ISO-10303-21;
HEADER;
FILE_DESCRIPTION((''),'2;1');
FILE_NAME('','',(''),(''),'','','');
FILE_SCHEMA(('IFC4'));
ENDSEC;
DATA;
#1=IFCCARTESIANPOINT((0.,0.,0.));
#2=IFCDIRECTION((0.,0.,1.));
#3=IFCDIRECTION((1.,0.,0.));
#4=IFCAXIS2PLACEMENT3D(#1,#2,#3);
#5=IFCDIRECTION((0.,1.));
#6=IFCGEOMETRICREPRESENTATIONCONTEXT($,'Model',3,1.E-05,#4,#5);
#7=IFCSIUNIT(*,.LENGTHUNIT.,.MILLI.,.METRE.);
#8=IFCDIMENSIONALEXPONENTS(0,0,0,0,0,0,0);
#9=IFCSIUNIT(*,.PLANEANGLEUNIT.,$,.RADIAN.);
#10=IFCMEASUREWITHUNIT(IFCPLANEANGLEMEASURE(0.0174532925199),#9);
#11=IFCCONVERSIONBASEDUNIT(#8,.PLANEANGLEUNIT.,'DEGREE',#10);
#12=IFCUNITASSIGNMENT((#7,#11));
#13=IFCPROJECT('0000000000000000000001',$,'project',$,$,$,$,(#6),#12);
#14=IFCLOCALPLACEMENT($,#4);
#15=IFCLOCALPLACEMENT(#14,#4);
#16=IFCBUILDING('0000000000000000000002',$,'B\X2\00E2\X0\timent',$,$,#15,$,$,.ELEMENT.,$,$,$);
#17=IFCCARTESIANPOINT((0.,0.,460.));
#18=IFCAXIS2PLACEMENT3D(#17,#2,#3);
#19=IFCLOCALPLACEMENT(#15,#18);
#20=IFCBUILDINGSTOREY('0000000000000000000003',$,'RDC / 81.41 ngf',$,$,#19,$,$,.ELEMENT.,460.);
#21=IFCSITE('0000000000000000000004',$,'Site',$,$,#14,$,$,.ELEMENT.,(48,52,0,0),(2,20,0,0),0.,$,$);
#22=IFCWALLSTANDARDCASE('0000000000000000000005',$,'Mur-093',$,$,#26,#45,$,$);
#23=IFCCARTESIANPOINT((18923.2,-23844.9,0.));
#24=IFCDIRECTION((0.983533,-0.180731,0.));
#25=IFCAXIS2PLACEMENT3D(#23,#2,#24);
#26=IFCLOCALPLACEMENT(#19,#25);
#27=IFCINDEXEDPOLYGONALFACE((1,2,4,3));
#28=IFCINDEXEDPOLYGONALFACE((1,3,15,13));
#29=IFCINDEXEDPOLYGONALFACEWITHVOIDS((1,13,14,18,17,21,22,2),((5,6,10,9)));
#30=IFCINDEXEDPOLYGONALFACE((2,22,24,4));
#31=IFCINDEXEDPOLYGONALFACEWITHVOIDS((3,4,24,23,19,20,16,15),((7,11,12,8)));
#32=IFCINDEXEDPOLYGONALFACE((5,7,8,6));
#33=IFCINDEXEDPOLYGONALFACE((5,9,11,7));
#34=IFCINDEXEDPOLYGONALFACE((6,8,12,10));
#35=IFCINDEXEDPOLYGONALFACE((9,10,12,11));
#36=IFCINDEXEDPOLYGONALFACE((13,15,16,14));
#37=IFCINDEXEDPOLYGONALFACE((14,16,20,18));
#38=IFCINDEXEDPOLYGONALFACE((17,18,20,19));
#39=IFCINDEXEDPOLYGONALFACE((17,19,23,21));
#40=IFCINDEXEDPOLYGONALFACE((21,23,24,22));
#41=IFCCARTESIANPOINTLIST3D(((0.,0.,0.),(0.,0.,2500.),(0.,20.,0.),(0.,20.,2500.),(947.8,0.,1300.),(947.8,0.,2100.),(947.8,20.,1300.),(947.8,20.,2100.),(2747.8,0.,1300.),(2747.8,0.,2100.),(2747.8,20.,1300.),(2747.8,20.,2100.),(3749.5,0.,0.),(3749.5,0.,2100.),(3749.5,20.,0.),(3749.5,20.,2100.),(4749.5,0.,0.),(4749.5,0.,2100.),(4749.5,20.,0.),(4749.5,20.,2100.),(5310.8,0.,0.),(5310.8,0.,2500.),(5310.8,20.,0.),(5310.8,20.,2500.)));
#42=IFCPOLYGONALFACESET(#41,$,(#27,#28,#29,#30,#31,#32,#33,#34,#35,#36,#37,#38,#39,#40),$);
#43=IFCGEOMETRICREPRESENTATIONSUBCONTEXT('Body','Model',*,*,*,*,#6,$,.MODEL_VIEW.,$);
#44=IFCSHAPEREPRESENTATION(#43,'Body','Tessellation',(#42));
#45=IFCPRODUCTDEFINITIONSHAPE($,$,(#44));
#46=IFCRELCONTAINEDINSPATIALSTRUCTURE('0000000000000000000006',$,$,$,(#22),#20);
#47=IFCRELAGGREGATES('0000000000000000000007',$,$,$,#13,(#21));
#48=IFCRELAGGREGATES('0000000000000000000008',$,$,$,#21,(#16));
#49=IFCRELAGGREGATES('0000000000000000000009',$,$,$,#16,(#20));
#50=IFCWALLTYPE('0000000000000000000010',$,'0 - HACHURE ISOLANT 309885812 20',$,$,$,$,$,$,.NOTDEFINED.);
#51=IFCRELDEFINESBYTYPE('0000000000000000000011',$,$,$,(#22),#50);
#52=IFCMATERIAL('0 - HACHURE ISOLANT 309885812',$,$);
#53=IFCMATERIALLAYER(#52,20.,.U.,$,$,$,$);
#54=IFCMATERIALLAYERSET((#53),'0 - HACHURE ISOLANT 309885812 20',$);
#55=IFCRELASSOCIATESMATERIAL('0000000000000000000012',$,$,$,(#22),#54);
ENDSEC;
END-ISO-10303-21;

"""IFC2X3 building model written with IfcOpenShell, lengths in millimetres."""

from ifc_helpers import new_model, entity, si_unit, converted_unit, direction, frame, origin_with_axes, origin_2d_with_axis, place, context, subcontext, project, spatial, polyline, rectangle, outline, extrude, material, layer, layer_set, layer_usage, type_object, element, save


model = new_model("IFC2X3")

# Units and contexts
model_context = context("Model", 3, precision=1e-05, world=origin_with_axes(), true_north=direction((0.0, 1.0)))
body_context = subcontext(model_context, "Body", "Model", "MODEL_VIEW")
ifc_project = project(units=[si_unit("LENGTHUNIT", "METRE", prefix="MILLI"), converted_unit("PLANEANGLEUNIT", "DEGREE", entity("IfcPlaneAngleMeasure", 0.0174532925199), si_unit("PLANEANGLEUNIT", "RADIAN"), dimensions=[0, 0, 0, 0, 0, 0, 0])], contexts=[model_context])

# Site, building, storey
site_placement = place(None, origin_with_axes())
site = spatial("IfcSite", under=ifc_project, at=site_placement, Name="Site", CompositionType="ELEMENT", RefLatitude=(48, 52, 0, 0), RefLongitude=(2, 20, 0, 0), RefElevation=0.0)
building_placement = place(site_placement, origin_with_axes())
building = spatial("IfcBuilding", under=site, at=building_placement, Name="Bâtiment", CompositionType="ELEMENT")
storey_placement = place(building_placement, frame((0.0, 0.0, 460.0), z_axis=(0.0, 0.0, 1.0), x_axis=(1.0, 0.0, 0.0)))
storey = spatial("IfcBuildingStorey", under=building, at=storey_placement, Name="RDC / 81.41 ngf", CompositionType="ELEMENT", Elevation=460.0)

# Shared definitions
ifc_material_1 = material(Name="0 - HACHURE ISOLANT 309885812")

# Wall, openings
ifc_layer_1 = layer(ifc_material_1, 20.0, ventilated="UNKNOWN")
ifc_layer_set_1 = layer_set([ifc_layer_1], Name="0 - HACHURE ISOLANT 309885812 20")
ifc_layer_usage_1 = layer_usage(ifc_layer_set_1, "AXIS2", "NEGATIVE", 20.0)
wall_type_1 = type_object("IfcWallType", Name="0 - HACHURE ISOLANT 309885812 20", PredefinedType="NOTDEFINED")
wall_1_placement = place(storey_placement, frame((18923.2, -23844.9, 0.0), z_axis=(0.0, 0.0, 1.0), x_axis=(0.983533, -0.180731, 0.0)))
wall_1 = element("IfcWallStandardCase", 1, at=wall_1_placement, inside=storey, type_object=wall_type_1, material=ifc_layer_usage_1, Name="Mur-093", context=body_context, shape_type="SweptSolid", body=[
    extrude(outline(polyline([(0.0, 0.0), (5310.8, 0.0), (5310.8, 20.0), (0.0, 20.0), (0.0, 0.0)])), origin_with_axes(), (0.0, 0.0, 1.0), 2500.0),
])
opening_1_placement = place(wall_1_placement, frame((1847.8, 0.0, 1300.0), z_axis=(0.0, 0.0, 1.0), x_axis=(1.0, 0.0, 0.0)))
element("IfcOpeningElement", 2, at=opening_1_placement, cuts=wall_1, context=body_context, shape_type="SweptSolid", body=[
    extrude(rectangle(XDim=1800.0, YDim=800.0, at=origin_2d_with_axis()), frame((0.0, 40.0, 400.0), z_axis=(0.0, -1.0, 0.0), x_axis=(1.0, 0.0, 0.0)), (0.0, 0.0, 1.0), 60.0),
])
opening_2_placement = place(wall_1_placement, frame((4249.5, 0.0, 0.0), z_axis=(0.0, 0.0, 1.0), x_axis=(1.0, 0.0, 0.0)))
element("IfcOpeningElement", 3, at=opening_2_placement, cuts=wall_1, context=body_context, shape_type="SweptSolid", body=[
    extrude(rectangle(XDim=1000.0, YDim=2100.0, at=origin_2d_with_axis()), frame((0.0, 40.0, 1050.0), z_axis=(0.0, -1.0, 0.0), x_axis=(1.0, 0.0, 0.0)), (0.0, 0.0, 1.0), 60.0),
])

save(model, "model.ifc")
